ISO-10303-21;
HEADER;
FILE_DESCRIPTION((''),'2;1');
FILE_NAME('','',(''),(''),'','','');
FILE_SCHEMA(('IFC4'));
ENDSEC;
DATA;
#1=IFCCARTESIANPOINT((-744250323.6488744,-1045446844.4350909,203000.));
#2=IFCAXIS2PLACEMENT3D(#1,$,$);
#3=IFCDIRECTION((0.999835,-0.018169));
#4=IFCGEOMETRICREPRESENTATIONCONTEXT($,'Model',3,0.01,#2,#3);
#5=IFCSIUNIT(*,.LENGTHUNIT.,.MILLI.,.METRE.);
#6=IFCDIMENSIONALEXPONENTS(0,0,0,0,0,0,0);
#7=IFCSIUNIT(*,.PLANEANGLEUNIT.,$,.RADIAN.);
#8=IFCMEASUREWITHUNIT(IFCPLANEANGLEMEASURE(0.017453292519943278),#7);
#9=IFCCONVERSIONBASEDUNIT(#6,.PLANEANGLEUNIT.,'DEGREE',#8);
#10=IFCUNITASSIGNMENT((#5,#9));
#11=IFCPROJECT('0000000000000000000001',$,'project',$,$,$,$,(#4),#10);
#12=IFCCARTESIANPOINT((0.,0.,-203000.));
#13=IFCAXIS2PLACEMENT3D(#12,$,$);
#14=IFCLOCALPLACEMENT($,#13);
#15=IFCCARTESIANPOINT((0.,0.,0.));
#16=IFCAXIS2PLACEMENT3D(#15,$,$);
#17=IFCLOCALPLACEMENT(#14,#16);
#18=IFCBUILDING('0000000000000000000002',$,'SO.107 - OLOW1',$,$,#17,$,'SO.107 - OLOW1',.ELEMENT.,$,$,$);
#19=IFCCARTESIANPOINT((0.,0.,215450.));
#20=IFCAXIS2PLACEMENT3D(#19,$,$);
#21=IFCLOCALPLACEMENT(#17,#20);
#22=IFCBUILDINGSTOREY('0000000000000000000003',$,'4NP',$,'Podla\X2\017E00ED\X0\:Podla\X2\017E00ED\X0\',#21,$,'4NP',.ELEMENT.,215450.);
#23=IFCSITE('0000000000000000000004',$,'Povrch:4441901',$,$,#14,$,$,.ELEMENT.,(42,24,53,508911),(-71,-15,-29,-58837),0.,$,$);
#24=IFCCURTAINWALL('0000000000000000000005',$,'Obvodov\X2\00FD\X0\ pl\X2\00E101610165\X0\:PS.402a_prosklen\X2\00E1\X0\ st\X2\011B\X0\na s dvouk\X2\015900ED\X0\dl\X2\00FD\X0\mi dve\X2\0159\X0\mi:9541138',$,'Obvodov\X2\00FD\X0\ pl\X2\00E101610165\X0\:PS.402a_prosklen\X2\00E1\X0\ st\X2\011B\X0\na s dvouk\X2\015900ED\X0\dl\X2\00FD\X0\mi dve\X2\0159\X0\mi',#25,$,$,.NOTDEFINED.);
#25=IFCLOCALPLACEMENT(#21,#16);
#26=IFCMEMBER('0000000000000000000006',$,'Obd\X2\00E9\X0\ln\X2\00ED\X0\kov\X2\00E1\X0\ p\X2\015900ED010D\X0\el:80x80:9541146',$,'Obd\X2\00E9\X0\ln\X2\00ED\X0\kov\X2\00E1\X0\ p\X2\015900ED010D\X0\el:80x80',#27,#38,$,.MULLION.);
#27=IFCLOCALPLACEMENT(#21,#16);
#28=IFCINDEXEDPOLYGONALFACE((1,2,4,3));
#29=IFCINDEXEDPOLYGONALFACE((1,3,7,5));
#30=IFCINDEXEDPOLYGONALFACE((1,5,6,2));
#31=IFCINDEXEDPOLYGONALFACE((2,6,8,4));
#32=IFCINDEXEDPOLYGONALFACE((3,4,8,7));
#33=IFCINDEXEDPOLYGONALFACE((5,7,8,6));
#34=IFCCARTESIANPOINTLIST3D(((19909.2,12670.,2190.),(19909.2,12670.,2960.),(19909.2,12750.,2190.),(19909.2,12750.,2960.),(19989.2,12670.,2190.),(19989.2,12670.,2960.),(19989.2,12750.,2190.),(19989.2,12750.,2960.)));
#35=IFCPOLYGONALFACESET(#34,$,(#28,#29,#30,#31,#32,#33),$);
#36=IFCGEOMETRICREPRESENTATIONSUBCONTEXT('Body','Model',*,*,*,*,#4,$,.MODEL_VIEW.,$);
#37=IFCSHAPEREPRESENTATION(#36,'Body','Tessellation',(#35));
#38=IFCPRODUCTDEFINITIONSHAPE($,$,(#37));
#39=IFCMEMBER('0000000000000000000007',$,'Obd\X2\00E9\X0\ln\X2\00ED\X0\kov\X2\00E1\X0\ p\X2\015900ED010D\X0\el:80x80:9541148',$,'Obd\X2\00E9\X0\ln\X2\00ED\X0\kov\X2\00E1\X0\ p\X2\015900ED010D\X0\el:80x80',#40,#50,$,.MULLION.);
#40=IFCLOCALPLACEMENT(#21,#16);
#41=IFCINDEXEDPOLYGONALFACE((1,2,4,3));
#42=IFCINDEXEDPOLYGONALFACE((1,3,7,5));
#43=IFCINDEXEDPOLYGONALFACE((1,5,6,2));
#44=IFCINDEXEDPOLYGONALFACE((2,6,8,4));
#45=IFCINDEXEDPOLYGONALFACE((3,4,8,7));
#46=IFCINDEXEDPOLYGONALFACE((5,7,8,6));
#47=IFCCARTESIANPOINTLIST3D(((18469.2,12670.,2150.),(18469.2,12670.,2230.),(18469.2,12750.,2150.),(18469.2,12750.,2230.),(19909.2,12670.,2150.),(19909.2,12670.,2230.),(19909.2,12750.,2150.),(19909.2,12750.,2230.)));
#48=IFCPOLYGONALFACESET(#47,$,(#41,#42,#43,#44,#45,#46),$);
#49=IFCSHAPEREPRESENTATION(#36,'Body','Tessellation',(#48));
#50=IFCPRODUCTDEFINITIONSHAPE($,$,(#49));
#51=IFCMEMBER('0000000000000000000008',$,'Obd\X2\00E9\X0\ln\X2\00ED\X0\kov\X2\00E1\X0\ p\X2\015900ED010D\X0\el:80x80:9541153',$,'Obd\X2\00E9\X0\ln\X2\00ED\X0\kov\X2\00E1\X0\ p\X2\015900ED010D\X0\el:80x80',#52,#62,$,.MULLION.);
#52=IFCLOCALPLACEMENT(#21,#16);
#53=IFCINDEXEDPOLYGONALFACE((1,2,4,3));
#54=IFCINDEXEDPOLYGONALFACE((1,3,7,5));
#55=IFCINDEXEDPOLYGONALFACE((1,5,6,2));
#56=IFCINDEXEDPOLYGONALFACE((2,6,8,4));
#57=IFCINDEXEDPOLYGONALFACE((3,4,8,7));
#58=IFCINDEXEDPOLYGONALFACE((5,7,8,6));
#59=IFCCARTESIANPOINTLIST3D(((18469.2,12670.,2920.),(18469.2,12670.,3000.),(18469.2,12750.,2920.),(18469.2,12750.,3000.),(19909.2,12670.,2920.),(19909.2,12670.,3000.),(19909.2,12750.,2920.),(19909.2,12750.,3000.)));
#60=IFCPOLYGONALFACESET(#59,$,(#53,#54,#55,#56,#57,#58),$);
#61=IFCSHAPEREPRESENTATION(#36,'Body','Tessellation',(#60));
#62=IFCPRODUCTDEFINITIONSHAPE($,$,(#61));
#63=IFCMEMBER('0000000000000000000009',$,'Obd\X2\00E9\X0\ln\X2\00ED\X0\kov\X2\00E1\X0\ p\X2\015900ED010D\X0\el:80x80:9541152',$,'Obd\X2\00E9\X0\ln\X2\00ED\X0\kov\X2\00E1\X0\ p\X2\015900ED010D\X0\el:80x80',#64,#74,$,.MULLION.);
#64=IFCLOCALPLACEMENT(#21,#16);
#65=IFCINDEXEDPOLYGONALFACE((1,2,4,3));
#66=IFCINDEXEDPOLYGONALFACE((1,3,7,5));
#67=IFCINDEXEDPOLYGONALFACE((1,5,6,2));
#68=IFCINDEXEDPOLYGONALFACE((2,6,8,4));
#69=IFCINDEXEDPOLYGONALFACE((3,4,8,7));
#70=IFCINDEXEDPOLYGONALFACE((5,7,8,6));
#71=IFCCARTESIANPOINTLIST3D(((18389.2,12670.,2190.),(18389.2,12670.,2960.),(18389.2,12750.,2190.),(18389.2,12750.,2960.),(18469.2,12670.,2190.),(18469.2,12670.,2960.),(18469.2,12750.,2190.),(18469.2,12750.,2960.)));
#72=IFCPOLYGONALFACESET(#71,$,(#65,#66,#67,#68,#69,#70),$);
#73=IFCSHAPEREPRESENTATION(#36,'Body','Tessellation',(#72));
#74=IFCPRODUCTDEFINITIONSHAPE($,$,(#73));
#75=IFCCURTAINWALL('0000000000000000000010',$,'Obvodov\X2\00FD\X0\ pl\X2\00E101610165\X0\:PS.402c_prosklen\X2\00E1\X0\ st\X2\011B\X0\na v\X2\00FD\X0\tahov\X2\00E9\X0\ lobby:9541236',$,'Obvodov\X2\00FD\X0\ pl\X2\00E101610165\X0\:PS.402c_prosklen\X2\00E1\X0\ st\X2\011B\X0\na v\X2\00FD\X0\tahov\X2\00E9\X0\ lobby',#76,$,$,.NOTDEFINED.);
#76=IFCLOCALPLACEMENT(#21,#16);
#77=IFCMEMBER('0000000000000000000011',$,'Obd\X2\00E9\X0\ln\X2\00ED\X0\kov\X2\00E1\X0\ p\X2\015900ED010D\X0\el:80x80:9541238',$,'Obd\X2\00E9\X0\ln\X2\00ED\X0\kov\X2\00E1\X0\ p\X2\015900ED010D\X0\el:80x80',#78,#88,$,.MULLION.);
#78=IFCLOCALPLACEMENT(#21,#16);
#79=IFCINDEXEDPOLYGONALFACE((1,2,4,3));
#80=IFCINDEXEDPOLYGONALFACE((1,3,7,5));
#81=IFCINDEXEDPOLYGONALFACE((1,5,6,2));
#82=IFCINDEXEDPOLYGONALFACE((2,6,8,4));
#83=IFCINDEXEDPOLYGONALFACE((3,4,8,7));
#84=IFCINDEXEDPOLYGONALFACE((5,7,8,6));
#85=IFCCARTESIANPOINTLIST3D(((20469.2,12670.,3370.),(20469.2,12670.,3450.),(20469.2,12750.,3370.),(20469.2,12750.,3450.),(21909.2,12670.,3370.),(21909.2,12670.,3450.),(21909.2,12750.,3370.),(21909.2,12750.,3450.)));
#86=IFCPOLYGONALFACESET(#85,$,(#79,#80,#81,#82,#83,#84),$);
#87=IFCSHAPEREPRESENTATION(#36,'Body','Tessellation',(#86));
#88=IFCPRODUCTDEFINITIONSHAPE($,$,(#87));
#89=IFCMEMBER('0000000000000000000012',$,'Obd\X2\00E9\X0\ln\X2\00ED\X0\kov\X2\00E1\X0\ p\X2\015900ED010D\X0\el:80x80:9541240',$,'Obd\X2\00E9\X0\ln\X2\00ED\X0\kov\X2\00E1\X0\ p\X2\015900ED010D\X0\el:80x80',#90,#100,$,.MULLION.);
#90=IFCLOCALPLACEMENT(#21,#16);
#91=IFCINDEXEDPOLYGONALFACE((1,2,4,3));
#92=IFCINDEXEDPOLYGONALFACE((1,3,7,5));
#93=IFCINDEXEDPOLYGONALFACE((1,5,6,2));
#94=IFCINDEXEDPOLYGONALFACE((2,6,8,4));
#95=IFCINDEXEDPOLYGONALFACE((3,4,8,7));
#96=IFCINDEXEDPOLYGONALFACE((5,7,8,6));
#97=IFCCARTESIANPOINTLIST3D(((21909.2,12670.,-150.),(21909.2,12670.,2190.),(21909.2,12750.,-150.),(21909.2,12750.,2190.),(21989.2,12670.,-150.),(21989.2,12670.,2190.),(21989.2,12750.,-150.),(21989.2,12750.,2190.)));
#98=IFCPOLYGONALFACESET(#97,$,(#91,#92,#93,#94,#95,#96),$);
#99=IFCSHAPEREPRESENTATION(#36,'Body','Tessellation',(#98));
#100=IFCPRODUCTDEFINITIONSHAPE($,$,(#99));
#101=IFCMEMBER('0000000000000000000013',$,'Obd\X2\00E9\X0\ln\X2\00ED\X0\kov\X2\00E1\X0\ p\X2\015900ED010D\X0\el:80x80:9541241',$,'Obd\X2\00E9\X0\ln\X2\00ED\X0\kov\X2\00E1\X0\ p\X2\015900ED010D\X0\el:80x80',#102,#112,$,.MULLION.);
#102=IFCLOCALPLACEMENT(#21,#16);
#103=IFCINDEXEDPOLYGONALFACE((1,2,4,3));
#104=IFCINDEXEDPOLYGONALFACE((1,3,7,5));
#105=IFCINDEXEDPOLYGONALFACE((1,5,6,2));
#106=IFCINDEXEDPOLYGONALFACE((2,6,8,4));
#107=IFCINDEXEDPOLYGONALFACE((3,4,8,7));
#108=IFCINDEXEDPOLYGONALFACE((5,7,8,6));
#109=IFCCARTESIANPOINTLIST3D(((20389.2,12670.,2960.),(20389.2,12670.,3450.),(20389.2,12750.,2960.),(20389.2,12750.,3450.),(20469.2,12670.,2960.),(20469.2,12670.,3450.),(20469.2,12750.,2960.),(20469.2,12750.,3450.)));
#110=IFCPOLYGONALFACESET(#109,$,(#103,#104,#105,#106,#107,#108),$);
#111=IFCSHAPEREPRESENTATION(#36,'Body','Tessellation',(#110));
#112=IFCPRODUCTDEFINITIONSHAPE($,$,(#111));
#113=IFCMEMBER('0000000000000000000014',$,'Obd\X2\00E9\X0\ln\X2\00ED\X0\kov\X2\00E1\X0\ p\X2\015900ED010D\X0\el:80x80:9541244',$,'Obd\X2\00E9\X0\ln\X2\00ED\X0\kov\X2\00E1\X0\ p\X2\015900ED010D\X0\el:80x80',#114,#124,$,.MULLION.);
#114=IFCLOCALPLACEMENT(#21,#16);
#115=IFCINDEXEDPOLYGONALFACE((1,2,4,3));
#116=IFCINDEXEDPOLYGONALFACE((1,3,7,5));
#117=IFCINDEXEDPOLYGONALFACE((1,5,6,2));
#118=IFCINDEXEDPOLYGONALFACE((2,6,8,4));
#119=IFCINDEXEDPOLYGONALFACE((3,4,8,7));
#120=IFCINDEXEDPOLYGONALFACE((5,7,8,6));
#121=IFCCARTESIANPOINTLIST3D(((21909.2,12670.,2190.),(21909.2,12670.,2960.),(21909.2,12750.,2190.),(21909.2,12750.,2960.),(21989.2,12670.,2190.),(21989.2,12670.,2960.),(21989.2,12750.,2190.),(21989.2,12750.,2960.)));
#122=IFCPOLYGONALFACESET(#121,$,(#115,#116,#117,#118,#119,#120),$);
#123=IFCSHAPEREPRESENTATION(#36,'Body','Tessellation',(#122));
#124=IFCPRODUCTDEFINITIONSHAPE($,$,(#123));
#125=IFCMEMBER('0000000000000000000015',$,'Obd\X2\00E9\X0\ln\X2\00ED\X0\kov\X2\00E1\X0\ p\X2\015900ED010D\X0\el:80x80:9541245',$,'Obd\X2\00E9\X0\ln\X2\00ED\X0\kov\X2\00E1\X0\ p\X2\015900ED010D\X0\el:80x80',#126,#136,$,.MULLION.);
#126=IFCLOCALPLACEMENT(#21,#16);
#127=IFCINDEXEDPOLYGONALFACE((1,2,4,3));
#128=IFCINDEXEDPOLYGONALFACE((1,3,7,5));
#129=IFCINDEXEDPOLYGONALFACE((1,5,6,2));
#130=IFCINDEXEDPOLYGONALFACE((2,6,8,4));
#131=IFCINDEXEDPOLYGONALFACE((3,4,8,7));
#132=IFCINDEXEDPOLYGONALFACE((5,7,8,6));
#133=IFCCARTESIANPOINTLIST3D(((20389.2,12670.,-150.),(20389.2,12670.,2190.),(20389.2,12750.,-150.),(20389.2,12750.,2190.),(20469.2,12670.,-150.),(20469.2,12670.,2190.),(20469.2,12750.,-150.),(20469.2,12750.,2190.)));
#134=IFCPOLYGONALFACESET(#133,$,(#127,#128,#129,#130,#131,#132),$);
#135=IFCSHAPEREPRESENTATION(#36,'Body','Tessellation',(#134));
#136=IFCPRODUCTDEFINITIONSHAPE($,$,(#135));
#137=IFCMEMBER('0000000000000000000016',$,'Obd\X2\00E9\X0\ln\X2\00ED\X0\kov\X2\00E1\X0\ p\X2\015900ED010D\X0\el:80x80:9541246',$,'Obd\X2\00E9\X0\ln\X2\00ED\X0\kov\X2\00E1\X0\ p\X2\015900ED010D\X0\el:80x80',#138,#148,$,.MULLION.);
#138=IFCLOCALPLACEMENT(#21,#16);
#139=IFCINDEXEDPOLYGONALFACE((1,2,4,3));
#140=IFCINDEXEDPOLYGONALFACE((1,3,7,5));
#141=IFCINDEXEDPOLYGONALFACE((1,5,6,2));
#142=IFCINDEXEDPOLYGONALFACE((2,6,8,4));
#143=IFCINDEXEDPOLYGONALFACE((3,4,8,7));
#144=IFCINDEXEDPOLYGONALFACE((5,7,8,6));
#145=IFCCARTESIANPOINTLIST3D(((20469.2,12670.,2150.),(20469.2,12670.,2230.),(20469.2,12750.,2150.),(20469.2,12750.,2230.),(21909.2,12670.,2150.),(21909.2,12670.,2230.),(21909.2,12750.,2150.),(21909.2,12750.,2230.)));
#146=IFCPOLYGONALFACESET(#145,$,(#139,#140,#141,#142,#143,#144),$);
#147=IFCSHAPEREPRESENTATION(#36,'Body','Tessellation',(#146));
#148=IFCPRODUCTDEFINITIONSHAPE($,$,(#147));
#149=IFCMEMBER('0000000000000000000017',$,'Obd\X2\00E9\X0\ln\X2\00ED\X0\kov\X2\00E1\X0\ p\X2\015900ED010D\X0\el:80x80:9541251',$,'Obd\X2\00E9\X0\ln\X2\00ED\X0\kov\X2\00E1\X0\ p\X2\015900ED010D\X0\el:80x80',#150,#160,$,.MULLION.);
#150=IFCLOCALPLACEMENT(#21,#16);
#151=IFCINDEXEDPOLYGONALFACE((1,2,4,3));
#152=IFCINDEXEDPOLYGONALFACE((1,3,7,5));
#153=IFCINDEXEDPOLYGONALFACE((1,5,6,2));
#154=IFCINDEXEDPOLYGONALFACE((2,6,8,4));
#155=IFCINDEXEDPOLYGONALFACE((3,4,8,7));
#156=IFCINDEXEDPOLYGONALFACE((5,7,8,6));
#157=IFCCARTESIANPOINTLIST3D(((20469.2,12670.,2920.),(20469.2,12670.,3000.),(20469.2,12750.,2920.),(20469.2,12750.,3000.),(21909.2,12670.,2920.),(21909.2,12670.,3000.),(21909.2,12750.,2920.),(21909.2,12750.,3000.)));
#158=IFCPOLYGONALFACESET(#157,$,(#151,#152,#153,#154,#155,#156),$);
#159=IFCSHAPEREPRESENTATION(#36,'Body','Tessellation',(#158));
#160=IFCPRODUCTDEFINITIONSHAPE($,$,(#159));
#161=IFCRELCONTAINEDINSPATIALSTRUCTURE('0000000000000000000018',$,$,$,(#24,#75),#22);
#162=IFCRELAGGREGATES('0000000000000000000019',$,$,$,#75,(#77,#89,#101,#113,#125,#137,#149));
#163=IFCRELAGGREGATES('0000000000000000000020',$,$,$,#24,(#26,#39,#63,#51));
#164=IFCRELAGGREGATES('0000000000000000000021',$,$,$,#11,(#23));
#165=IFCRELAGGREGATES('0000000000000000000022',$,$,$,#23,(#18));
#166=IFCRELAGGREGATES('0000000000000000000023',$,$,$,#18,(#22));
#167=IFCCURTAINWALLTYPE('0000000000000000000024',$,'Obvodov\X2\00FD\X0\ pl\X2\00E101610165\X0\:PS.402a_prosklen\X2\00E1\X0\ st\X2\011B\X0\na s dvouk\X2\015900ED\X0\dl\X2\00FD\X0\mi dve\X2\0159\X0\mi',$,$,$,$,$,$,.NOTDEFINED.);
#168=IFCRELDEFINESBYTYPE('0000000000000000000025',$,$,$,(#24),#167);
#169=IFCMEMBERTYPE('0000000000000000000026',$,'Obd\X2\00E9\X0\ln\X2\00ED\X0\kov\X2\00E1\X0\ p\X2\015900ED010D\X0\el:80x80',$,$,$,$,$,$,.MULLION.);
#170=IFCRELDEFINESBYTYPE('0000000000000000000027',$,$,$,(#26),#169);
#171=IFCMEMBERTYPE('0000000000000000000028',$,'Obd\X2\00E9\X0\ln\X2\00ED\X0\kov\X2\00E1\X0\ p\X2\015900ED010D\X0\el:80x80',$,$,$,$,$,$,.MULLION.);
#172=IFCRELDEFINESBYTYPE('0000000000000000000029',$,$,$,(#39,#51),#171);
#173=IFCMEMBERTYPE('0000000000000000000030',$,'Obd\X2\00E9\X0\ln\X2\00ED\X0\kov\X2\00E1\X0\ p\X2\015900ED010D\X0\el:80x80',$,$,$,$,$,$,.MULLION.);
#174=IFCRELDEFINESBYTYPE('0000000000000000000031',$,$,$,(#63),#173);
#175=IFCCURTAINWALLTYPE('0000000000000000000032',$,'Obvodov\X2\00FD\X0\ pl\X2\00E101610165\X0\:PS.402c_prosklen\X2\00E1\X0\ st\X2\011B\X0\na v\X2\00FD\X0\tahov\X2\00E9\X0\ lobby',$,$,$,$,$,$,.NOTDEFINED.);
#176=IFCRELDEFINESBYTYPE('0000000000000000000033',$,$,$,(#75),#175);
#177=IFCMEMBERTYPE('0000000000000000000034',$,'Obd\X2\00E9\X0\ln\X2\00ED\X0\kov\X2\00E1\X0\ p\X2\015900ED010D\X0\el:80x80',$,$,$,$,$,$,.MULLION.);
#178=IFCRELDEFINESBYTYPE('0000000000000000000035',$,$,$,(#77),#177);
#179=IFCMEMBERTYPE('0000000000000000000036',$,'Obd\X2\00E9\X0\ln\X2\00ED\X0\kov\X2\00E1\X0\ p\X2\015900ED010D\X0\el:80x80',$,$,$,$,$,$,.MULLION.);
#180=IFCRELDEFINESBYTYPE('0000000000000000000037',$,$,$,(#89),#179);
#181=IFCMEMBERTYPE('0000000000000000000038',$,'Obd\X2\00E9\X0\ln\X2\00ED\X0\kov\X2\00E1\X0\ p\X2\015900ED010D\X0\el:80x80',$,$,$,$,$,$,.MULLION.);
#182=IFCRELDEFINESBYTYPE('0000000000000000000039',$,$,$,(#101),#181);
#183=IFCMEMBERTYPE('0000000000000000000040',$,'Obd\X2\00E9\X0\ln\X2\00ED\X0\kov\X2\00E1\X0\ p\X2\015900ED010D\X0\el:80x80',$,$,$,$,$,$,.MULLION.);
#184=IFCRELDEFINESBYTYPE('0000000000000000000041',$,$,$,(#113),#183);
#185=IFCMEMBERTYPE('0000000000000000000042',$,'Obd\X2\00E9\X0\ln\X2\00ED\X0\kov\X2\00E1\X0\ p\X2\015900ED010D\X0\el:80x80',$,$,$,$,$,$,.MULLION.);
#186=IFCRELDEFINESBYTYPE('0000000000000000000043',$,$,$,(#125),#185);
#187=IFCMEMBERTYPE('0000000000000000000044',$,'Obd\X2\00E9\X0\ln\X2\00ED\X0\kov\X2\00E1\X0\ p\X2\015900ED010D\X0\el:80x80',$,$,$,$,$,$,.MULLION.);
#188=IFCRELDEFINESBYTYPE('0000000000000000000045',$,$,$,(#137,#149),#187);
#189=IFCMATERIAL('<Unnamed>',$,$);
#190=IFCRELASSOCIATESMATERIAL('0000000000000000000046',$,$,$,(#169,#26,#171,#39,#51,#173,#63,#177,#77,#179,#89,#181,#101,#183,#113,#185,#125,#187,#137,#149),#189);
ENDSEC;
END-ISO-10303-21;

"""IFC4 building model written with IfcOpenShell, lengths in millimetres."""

from ifc_helpers import new_model, entity, si_unit, converted_unit, direction, frame, origin, place, context, subcontext, project, spatial, indexed_curve, outline, extrude, source, transform, mapped, material, type_object, type_shapes, element, aggregate, save


model = new_model("IFC4")

# Units and contexts
model_context = context("Model", 3, precision=0.01, world=frame((-744250323.6488744, -1045446844.4350909, 203000.0)), true_north=direction((0.999835, -0.018169)))
body_context = subcontext(model_context, "Body", "Model", "MODEL_VIEW")
ifc_project = project(units=[si_unit("LENGTHUNIT", "METRE", prefix="MILLI"), converted_unit("PLANEANGLEUNIT", "DEGREE", entity("IfcPlaneAngleMeasure", 0.017453292519943278), si_unit("PLANEANGLEUNIT", "RADIAN"), dimensions=[0, 0, 0, 0, 0, 0, 0])], contexts=[model_context])

# Site, building, storey
site_placement = place(None, frame((0.0, 0.0, -203000.0)))
site = spatial("IfcSite", under=ifc_project, at=site_placement, Name="Povrch:4441901", CompositionType="ELEMENT", RefLatitude=(42, 24, 53, 508911), RefLongitude=(-71, -15, -29, -58837), RefElevation=0.0)
building_placement = place(site_placement, origin())
building = spatial("IfcBuilding", under=site, at=building_placement, Name="SO.107 - OLOW1", LongName="SO.107 - OLOW1", CompositionType="ELEMENT")
storey_placement = place(building_placement, frame((0.0, 0.0, 215450.0)))
storey = spatial("IfcBuildingStorey", under=building, at=storey_placement, Name="4NP", ObjectType="Podlaží:Podlaží", LongName="4NP", CompositionType="ELEMENT", Elevation=215450.0)

# Curtain walls, members
curtain_wall_type_1 = type_object("IfcCurtainWallType", Name="Obvodový plášť:PS.402a_prosklená stěna s dvoukřídlými dveřmi", PredefinedType="NOTDEFINED")
curtain_wall_1_placement = place(storey_placement, frame((0.0, 0.0, -215450.0)))
curtain_wall_1 = element("IfcCurtainWall", 1, at=curtain_wall_1_placement, inside=storey, type_object=curtain_wall_type_1, Name="Obvodový plášť:PS.402a_prosklená stěna s dvoukřídlými dveřmi:9541138", ObjectType="Obvodový plášť:PS.402a_prosklená stěna s dvoukřídlými dveřmi", PredefinedType="NOTDEFINED")
ifc_material_1 = material(Name="<Unnamed>")
member_type_1 = type_object("IfcMemberType", Name="Obdélníková příčel:80x80", PredefinedType="MULLION", material=ifc_material_1)
shared_shape_1 = source(origin(), body_context, "Body", "SweptSolid", [
    extrude(outline(indexed_curve([(-40.0, -40.0), (40.0, -40.0), (40.0, 40.0), (-40.0, 40.0), (-40.0, -40.0)], self_intersect=False)), frame((-40.0, 0.0, -770.0), z_axis=(0.0, 0.0, 1.0), x_axis=(-1.0, 0.0, 0.0)), (0.0, 0.0, 1.0), 770.0),
])
type_shapes(member_type_1, [shared_shape_1])
member_1_placement = place(curtain_wall_1_placement, frame((19989.2, 12710.0, 217640.0), z_axis=(0.0, 0.0, -1.0), x_axis=(1.0, 0.0, 0.0)))
member_1 = element("IfcMember", 2, at=member_1_placement, type_object=member_type_1, material=ifc_material_1, Name="Obdélníková příčel:80x80:9541146", ObjectType="Obdélníková příčel:80x80", PredefinedType="MULLION", context=body_context, shape_type="MappedRepresentation", body=[
    mapped(shared_shape_1, transform((0.0, 0.0, 0.0), scale=1.0)),
])
member_type_2 = type_object("IfcMemberType", Name="Obdélníková příčel:80x80", PredefinedType="MULLION", material=ifc_material_1)
shared_shape_2 = source(origin(), body_context, "Body", "SweptSolid", [
    extrude(outline(indexed_curve([(-40.0, -40.0), (40.0, -40.0), (40.0, 40.0), (-40.0, 40.0), (-40.0, -40.0)], self_intersect=False)), frame((0.0, 0.0, -1440.0), z_axis=(0.0, 0.0, 1.0), x_axis=(-1.0, 0.0, 0.0)), (0.0, 0.0, 1.0), 1440.0),
])
type_shapes(member_type_2, [shared_shape_2])
member_2_placement = place(curtain_wall_1_placement, frame((19909.2, 12710.0, 217640.0), z_axis=(1.0, 0.0, 0.0), x_axis=(0.0, 0.0, 1.0)))
member_2 = element("IfcMember", 3, at=member_2_placement, type_object=member_type_2, material=ifc_material_1, Name="Obdélníková příčel:80x80:9541148", ObjectType="Obdélníková příčel:80x80", PredefinedType="MULLION", context=body_context, shape_type="MappedRepresentation", body=[
    mapped(shared_shape_2, transform((0.0, 0.0, 0.0), scale=1.0)),
])
member_3_placement = place(curtain_wall_1_placement, frame((19909.2, 12710.0, 218410.0), z_axis=(1.0, 0.0, 0.0), x_axis=(0.0, 0.0, 1.0)))
member_3 = element("IfcMember", 4, at=member_3_placement, type_object=member_type_2, material=ifc_material_1, Name="Obdélníková příčel:80x80:9541153", ObjectType="Obdélníková příčel:80x80", PredefinedType="MULLION", context=body_context, shape_type="MappedRepresentation", body=[
    mapped(shared_shape_2, transform((0.0, 0.0, 0.0), scale=1.0)),
])
member_type_3 = type_object("IfcMemberType", Name="Obdélníková příčel:80x80", PredefinedType="MULLION", material=ifc_material_1)
shared_shape_3 = source(origin(), body_context, "Body", "SweptSolid", [
    extrude(outline(indexed_curve([(-40.0, -40.0), (40.0, -40.0), (40.0, 40.0), (-40.0, 40.0), (-40.0, -40.0)], self_intersect=False)), frame((-40.0, 0.0, -770.0), z_axis=(0.0, 0.0, 1.0), x_axis=(-1.0, 0.0, 0.0)), (0.0, 0.0, 1.0), 770.0),
])
type_shapes(member_type_3, [shared_shape_3])
member_4_placement = place(curtain_wall_1_placement, frame((18389.2, 12710.0, 218410.0), z_axis=(0.0, 0.0, 1.0), x_axis=(-1.0, 0.0, 0.0)))
member_4 = element("IfcMember", 5, at=member_4_placement, type_object=member_type_3, material=ifc_material_1, Name="Obdélníková příčel:80x80:9541152", ObjectType="Obdélníková příčel:80x80", PredefinedType="MULLION", context=body_context, shape_type="MappedRepresentation", body=[
    mapped(shared_shape_3, transform((0.0, 0.0, 0.0), scale=1.0)),
])
curtain_wall_type_2 = type_object("IfcCurtainWallType", Name="Obvodový plášť:PS.402c_prosklená stěna výtahové lobby", PredefinedType="NOTDEFINED")
curtain_wall_2_placement = place(storey_placement, frame((0.0, 0.0, -215450.0)))
curtain_wall_2 = element("IfcCurtainWall", 6, at=curtain_wall_2_placement, inside=storey, type_object=curtain_wall_type_2, Name="Obvodový plášť:PS.402c_prosklená stěna výtahové lobby:9541236", ObjectType="Obvodový plášť:PS.402c_prosklená stěna výtahové lobby", PredefinedType="NOTDEFINED")
member_type_4 = type_object("IfcMemberType", Name="Obdélníková příčel:80x80", PredefinedType="MULLION", material=ifc_material_1)
shared_shape_4 = source(origin(), body_context, "Body", "SweptSolid", [
    extrude(outline(indexed_curve([(-40.0, -40.0), (40.0, -40.0), (40.0, 40.0), (-40.0, 40.0), (-40.0, -40.0)], self_intersect=False)), frame((-40.0, 0.0, -1440.0), z_axis=(0.0, 0.0, 1.0), x_axis=(-1.0, 0.0, 0.0)), (0.0, 0.0, 1.0), 1440.0),
])
type_shapes(member_type_4, [shared_shape_4])
member_5_placement = place(curtain_wall_2_placement, frame((21909.2, 12710.0, 218900.0), z_axis=(1.0, 0.0, 0.0), x_axis=(0.0, 0.0, 1.0)))
member_5 = element("IfcMember", 7, at=member_5_placement, type_object=member_type_4, material=ifc_material_1, Name="Obdélníková příčel:80x80:9541238", ObjectType="Obdélníková příčel:80x80", PredefinedType="MULLION", context=body_context, shape_type="MappedRepresentation", body=[
    mapped(shared_shape_4, transform((0.0, 0.0, 0.0), scale=1.0)),
])
member_type_5 = type_object("IfcMemberType", Name="Obdélníková příčel:80x80", PredefinedType="MULLION", material=ifc_material_1)
shared_shape_5 = source(origin(), body_context, "Body", "SweptSolid", [
    extrude(outline(indexed_curve([(-40.0, -40.0), (40.0, -40.0), (40.0, 40.0), (-40.0, 40.0), (-40.0, -40.0)], self_intersect=False)), frame((-40.0, 0.0, -2340.0), z_axis=(0.0, 0.0, 1.0), x_axis=(-1.0, 0.0, 0.0)), (0.0, 0.0, 1.0), 2340.0),
])
type_shapes(member_type_5, [shared_shape_5])
member_6_placement = place(curtain_wall_2_placement, frame((21989.2, 12710.0, 215300.0), z_axis=(0.0, 0.0, -1.0), x_axis=(1.0, 0.0, 0.0)))
member_6 = element("IfcMember", 8, at=member_6_placement, type_object=member_type_5, material=ifc_material_1, Name="Obdélníková příčel:80x80:9541240", ObjectType="Obdélníková příčel:80x80", PredefinedType="MULLION", context=body_context, shape_type="MappedRepresentation", body=[
    mapped(shared_shape_5, transform((0.0, 0.0, 0.0), scale=1.0)),
])
member_type_6 = type_object("IfcMemberType", Name="Obdélníková příčel:80x80", PredefinedType="MULLION", material=ifc_material_1)
shared_shape_6 = source(origin(), body_context, "Body", "SweptSolid", [
    extrude(outline(indexed_curve([(-40.0, -40.0), (40.0, -40.0), (40.0, 40.0), (-40.0, 40.0), (-40.0, -40.0)], self_intersect=False)), frame((-40.0, 0.0, -490.0), z_axis=(0.0, 0.0, 1.0), x_axis=(-1.0, 0.0, 0.0)), (0.0, 0.0, 1.0), 490.0),
])
type_shapes(member_type_6, [shared_shape_6])
member_7_placement = place(curtain_wall_2_placement, frame((20389.2, 12710.0, 218900.0), z_axis=(0.0, 0.0, 1.0), x_axis=(-1.0, 0.0, 0.0)))
member_7 = element("IfcMember", 9, at=member_7_placement, type_object=member_type_6, material=ifc_material_1, Name="Obdélníková příčel:80x80:9541241", ObjectType="Obdélníková příčel:80x80", PredefinedType="MULLION", context=body_context, shape_type="MappedRepresentation", body=[
    mapped(shared_shape_6, transform((0.0, 0.0, 0.0), scale=1.0)),
])
member_type_7 = type_object("IfcMemberType", Name="Obdélníková příčel:80x80", PredefinedType="MULLION", material=ifc_material_1)
shared_shape_7 = source(origin(), body_context, "Body", "SweptSolid", [
    extrude(outline(indexed_curve([(-40.0, -40.0), (40.0, -40.0), (40.0, 40.0), (-40.0, 40.0), (-40.0, -40.0)], self_intersect=False)), frame((-40.0, 0.0, -770.0), z_axis=(0.0, 0.0, 1.0), x_axis=(-1.0, 0.0, 0.0)), (0.0, 0.0, 1.0), 770.0),
])
type_shapes(member_type_7, [shared_shape_7])
member_8_placement = place(curtain_wall_2_placement, frame((21989.2, 12710.0, 217640.0), z_axis=(0.0, 0.0, -1.0), x_axis=(1.0, 0.0, 0.0)))
member_8 = element("IfcMember", 10, at=member_8_placement, type_object=member_type_7, material=ifc_material_1, Name="Obdélníková příčel:80x80:9541244", ObjectType="Obdélníková příčel:80x80", PredefinedType="MULLION", context=body_context, shape_type="MappedRepresentation", body=[
    mapped(shared_shape_7, transform((0.0, 0.0, 0.0), scale=1.0)),
])
member_type_8 = type_object("IfcMemberType", Name="Obdélníková příčel:80x80", PredefinedType="MULLION", material=ifc_material_1)
shared_shape_8 = source(origin(), body_context, "Body", "SweptSolid", [
    extrude(outline(indexed_curve([(-40.0, -40.0), (40.0, -40.0), (40.0, 40.0), (-40.0, 40.0), (-40.0, -40.0)], self_intersect=False)), frame((-40.0, 0.0, -2340.0), z_axis=(0.0, 0.0, 1.0), x_axis=(-1.0, 0.0, 0.0)), (0.0, 0.0, 1.0), 2340.0),
])
type_shapes(member_type_8, [shared_shape_8])
member_9_placement = place(curtain_wall_2_placement, frame((20389.2, 12710.0, 217640.0), z_axis=(0.0, 0.0, 1.0), x_axis=(-1.0, 0.0, 0.0)))
member_9 = element("IfcMember", 11, at=member_9_placement, type_object=member_type_8, material=ifc_material_1, Name="Obdélníková příčel:80x80:9541245", ObjectType="Obdélníková příčel:80x80", PredefinedType="MULLION", context=body_context, shape_type="MappedRepresentation", body=[
    mapped(shared_shape_8, transform((0.0, 0.0, 0.0), scale=1.0)),
])
member_type_9 = type_object("IfcMemberType", Name="Obdélníková příčel:80x80", PredefinedType="MULLION", material=ifc_material_1)
shared_shape_9 = source(origin(), body_context, "Body", "SweptSolid", [
    extrude(outline(indexed_curve([(-40.0, -40.0), (40.0, -40.0), (40.0, 40.0), (-40.0, 40.0), (-40.0, -40.0)], self_intersect=False)), frame((0.0, 0.0, -1440.0), z_axis=(0.0, 0.0, 1.0), x_axis=(-1.0, 0.0, 0.0)), (0.0, 0.0, 1.0), 1440.0),
])
type_shapes(member_type_9, [shared_shape_9])
member_10_placement = place(curtain_wall_2_placement, frame((21909.2, 12710.0, 217640.0), z_axis=(1.0, 0.0, 0.0), x_axis=(0.0, 0.0, 1.0)))
member_10 = element("IfcMember", 12, at=member_10_placement, type_object=member_type_9, material=ifc_material_1, Name="Obdélníková příčel:80x80:9541246", ObjectType="Obdélníková příčel:80x80", PredefinedType="MULLION", context=body_context, shape_type="MappedRepresentation", body=[
    mapped(shared_shape_9, transform((0.0, 0.0, 0.0), scale=1.0)),
])
member_11_placement = place(curtain_wall_2_placement, frame((21909.2, 12710.0, 218410.0), z_axis=(1.0, 0.0, 0.0), x_axis=(0.0, 0.0, 1.0)))
member_11 = element("IfcMember", 13, at=member_11_placement, type_object=member_type_9, material=ifc_material_1, Name="Obdélníková příčel:80x80:9541251", ObjectType="Obdélníková příčel:80x80", PredefinedType="MULLION", context=body_context, shape_type="MappedRepresentation", body=[
    mapped(shared_shape_9, transform((0.0, 0.0, 0.0), scale=1.0)),
])

aggregate(curtain_wall_2, [member_5, member_6, member_7, member_8, member_9, member_10, member_11])

aggregate(curtain_wall_1, [member_1, member_2, member_4, member_3])

save(model, "model.ifc")
